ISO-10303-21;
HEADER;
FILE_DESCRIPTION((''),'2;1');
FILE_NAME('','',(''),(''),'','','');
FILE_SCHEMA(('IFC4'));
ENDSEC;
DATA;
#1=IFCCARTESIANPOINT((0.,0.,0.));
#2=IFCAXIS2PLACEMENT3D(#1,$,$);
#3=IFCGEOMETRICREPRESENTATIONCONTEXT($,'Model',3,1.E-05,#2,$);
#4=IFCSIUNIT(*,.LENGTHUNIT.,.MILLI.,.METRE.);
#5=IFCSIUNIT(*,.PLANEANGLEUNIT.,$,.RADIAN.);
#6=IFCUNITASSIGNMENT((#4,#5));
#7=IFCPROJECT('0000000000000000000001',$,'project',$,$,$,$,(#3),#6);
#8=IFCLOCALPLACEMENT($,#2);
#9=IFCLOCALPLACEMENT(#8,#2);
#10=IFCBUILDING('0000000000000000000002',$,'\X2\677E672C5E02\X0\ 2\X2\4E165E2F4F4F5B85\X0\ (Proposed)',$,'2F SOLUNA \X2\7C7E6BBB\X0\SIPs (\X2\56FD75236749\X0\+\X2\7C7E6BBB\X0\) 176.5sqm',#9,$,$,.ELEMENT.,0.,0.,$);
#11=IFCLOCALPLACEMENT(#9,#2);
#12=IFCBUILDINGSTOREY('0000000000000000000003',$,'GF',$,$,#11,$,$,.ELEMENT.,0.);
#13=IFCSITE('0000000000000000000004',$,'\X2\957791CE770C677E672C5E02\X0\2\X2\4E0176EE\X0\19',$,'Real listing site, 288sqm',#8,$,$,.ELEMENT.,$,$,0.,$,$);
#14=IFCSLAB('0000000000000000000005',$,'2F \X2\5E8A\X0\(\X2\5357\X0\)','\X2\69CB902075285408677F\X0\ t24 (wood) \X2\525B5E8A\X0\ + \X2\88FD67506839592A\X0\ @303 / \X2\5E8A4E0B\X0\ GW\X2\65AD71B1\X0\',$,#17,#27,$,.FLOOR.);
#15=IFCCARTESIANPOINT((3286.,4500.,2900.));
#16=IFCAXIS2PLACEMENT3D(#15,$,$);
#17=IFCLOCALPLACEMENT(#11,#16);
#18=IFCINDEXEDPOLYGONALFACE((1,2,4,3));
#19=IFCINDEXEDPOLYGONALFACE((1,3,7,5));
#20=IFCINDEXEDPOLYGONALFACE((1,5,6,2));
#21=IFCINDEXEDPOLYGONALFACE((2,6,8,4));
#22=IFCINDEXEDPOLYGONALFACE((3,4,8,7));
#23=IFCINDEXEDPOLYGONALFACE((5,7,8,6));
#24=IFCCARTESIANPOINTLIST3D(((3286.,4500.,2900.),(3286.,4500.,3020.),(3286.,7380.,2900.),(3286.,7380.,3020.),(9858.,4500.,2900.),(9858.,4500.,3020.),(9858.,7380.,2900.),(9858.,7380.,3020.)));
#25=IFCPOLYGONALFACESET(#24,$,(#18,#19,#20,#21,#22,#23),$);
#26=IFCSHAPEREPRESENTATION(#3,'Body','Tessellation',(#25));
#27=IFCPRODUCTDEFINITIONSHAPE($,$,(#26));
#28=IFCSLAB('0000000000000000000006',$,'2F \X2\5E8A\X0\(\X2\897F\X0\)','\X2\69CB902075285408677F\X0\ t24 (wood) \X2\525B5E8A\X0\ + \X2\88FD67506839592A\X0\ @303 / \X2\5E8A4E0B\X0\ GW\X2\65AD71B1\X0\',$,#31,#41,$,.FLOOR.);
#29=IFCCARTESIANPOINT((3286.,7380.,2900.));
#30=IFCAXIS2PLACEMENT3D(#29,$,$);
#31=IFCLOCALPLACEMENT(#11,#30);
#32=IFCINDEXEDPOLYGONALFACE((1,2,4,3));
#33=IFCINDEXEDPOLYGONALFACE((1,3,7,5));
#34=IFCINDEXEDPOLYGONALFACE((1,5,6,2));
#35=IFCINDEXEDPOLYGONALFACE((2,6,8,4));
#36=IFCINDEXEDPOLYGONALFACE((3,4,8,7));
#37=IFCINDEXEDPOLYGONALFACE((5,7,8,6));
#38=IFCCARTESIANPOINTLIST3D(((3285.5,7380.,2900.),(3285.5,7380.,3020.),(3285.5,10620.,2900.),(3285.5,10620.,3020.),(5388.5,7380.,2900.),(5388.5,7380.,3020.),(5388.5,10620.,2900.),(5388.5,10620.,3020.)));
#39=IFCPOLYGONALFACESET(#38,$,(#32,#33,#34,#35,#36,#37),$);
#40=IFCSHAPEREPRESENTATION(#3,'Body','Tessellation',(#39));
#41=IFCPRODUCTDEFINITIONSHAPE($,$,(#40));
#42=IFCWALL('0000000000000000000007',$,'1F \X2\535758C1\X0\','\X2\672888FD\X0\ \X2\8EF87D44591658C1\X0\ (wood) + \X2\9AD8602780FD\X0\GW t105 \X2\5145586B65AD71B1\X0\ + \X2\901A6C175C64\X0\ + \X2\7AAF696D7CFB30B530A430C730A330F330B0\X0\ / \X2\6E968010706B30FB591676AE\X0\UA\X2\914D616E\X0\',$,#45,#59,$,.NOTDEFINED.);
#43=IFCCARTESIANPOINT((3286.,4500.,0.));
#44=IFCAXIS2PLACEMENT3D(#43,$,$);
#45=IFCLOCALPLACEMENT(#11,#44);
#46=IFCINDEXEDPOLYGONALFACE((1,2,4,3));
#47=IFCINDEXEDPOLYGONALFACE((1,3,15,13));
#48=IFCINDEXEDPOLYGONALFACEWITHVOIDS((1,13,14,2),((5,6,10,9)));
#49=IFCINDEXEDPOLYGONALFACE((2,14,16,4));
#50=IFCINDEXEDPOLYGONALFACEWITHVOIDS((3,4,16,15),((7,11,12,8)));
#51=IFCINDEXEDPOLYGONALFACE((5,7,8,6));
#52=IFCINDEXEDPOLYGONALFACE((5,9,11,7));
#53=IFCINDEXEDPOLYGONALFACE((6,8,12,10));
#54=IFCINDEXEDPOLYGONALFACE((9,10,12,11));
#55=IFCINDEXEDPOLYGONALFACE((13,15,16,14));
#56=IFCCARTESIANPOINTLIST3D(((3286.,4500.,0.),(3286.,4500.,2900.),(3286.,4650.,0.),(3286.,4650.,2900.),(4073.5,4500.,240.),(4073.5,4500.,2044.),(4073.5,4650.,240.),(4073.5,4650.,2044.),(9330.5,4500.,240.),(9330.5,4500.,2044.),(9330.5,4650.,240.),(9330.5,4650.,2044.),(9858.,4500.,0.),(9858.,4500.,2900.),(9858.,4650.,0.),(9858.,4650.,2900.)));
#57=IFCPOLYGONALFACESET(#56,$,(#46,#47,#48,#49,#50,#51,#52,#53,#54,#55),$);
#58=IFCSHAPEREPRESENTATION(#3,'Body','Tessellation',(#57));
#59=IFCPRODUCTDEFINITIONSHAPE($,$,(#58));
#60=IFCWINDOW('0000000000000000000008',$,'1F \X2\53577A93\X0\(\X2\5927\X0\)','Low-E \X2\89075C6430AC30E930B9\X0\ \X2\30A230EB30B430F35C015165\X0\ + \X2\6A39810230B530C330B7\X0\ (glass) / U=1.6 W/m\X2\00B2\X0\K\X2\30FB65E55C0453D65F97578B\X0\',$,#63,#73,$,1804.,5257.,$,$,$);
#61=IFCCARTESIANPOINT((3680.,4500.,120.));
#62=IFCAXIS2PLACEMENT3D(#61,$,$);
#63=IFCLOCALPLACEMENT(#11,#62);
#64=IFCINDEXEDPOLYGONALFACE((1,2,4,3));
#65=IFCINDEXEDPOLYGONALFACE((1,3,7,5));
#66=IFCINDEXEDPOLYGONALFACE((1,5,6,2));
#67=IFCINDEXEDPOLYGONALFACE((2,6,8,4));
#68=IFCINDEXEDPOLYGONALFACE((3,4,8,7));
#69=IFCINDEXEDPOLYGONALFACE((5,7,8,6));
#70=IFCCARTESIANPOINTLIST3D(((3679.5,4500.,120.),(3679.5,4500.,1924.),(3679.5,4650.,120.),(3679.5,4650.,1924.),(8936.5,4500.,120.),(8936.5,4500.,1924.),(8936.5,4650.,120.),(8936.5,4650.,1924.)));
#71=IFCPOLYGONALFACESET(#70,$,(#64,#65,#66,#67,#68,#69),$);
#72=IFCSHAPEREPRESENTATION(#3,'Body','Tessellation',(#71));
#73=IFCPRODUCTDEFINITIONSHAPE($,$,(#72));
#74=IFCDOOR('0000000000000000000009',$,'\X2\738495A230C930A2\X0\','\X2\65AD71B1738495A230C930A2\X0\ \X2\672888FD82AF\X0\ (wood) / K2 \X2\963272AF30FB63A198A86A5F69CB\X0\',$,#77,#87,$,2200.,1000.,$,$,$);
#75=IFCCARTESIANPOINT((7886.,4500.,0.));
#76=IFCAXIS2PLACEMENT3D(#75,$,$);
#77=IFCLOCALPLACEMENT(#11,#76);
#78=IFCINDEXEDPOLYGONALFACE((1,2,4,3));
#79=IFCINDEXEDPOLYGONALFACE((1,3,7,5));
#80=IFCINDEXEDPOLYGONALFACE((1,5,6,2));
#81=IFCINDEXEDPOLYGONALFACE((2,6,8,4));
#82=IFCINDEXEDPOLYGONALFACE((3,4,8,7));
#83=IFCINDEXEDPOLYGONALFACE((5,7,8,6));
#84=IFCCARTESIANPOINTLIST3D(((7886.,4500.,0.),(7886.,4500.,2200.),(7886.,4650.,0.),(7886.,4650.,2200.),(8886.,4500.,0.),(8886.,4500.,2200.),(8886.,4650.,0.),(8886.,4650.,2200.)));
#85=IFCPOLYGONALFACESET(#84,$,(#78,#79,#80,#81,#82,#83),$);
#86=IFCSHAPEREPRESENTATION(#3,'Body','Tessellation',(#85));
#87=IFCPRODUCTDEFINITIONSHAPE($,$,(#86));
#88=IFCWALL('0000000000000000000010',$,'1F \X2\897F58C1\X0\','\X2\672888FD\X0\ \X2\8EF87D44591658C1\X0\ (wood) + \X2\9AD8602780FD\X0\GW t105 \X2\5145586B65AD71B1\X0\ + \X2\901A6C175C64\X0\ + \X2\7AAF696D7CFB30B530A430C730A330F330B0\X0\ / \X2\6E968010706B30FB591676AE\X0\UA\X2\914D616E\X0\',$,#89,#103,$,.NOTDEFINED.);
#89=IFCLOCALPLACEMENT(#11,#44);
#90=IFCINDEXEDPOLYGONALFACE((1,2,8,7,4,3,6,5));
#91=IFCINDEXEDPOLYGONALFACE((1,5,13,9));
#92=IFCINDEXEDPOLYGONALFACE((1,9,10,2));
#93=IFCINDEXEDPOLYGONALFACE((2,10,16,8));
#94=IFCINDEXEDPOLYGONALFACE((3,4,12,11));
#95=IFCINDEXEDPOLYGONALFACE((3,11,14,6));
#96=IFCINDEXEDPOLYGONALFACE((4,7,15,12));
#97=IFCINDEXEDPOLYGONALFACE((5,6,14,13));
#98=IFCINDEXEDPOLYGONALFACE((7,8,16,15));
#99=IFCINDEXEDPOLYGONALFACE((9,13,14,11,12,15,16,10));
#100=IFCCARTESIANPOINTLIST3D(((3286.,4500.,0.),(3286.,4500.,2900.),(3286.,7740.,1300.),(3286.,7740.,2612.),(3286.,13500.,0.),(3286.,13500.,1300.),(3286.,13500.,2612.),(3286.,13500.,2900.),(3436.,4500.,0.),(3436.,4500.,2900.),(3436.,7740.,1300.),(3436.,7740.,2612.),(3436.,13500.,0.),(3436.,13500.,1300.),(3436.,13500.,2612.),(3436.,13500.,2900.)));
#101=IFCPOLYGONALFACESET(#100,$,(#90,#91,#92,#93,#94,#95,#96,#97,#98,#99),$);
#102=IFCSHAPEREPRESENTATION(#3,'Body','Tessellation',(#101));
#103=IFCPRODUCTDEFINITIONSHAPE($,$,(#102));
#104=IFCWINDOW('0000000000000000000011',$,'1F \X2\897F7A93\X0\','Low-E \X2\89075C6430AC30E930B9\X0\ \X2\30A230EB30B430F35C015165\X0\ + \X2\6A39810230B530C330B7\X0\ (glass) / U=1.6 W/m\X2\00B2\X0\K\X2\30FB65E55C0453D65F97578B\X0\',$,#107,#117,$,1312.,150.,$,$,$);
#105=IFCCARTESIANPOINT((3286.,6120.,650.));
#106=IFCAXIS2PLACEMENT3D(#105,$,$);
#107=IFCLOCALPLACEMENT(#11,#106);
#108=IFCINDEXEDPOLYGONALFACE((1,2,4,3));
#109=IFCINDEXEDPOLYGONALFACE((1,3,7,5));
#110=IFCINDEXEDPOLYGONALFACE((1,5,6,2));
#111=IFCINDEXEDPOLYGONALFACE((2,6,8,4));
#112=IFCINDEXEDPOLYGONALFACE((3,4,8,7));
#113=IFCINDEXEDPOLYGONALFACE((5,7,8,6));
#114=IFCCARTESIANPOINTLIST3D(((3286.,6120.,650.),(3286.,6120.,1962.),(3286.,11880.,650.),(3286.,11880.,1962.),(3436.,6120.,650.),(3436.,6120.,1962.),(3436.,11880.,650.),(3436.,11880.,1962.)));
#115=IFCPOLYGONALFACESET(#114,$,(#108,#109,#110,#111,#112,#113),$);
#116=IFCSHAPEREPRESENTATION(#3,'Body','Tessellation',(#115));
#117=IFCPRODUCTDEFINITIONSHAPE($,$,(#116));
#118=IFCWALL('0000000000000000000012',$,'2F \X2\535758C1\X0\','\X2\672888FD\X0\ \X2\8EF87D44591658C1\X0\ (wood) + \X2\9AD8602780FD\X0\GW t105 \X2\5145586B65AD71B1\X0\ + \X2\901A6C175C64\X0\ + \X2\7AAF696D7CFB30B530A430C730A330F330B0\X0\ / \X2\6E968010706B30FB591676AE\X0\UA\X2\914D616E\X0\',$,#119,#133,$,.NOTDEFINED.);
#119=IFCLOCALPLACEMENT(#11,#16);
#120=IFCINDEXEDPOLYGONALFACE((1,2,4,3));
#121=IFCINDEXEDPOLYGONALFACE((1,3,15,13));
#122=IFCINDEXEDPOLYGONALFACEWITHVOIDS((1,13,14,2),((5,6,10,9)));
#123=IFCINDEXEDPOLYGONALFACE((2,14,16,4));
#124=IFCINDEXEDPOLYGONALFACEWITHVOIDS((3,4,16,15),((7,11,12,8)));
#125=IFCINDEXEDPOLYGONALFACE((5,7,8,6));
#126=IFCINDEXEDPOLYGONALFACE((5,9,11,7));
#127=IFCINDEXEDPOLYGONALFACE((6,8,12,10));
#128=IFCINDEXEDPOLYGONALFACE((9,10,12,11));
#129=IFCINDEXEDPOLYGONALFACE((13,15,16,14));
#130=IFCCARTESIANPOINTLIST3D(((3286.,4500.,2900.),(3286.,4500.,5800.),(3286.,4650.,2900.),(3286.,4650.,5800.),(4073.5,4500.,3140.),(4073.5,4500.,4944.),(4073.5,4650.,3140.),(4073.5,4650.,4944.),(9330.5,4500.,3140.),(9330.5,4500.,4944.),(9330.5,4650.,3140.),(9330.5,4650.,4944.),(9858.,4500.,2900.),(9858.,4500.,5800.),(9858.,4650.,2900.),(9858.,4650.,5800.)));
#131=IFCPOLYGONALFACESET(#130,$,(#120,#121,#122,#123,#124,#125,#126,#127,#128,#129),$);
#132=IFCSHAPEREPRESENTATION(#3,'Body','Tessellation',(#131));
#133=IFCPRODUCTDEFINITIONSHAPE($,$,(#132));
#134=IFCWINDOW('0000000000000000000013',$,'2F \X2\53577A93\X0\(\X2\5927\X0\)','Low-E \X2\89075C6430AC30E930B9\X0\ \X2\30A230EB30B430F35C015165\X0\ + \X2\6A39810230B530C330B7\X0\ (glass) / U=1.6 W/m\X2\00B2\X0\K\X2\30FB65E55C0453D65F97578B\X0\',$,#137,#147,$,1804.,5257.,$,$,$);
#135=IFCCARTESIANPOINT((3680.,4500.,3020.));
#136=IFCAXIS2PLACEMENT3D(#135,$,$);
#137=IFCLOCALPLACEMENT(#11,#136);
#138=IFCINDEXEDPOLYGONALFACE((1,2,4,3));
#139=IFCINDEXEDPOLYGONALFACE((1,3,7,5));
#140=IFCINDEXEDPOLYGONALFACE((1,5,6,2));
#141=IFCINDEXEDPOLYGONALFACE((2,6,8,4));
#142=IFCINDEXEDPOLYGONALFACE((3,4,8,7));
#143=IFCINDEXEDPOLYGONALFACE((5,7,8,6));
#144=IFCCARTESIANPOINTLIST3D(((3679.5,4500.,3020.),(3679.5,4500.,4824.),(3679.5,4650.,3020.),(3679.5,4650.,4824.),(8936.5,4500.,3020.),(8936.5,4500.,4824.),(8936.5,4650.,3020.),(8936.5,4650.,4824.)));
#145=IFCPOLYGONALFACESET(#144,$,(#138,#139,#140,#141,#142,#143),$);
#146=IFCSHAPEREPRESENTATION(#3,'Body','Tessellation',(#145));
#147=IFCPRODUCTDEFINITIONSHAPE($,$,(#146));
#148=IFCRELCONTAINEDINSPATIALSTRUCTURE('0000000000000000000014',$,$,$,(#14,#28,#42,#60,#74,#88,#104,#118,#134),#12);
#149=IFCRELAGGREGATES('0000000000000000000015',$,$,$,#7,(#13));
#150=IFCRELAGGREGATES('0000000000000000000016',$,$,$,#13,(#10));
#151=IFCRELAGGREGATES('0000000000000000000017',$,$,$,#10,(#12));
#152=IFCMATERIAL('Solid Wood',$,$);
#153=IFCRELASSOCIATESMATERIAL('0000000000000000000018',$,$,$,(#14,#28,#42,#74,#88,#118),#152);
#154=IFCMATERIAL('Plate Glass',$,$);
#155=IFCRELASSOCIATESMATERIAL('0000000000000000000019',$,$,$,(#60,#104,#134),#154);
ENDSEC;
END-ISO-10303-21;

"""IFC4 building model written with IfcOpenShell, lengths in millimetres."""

from ifc_helpers import new_model, si_unit, frame, frame_2d, origin, place, context, project, spatial, rectangle, extrude, material, element, fill, save


model = new_model("IFC4")

# Units and contexts
model_context = context("Model", 3, precision=1e-05, world=origin())
ifc_project = project(units=[si_unit("LENGTHUNIT", "METRE", prefix="MILLI"), si_unit("PLANEANGLEUNIT", "RADIAN")], contexts=[model_context])

# Site, building, storey
site_placement = place(None, origin())
site = spatial("IfcSite", under=ifc_project, at=site_placement, Name="長野県松本市2丁目19", ObjectType="Real listing site, 288sqm", CompositionType="ELEMENT", RefElevation=0.0)
building_placement = place(site_placement, origin())
building = spatial("IfcBuilding", under=site, at=building_placement, Name="松本市 2世帯住宅 (Proposed)", ObjectType="2F SOLUNA 籾殻SIPs (国産杉+籾殻) 176.5sqm", CompositionType="ELEMENT", ElevationOfRefHeight=0.0, ElevationOfTerrain=0.0)
storey_placement = place(building_placement, origin())
storey = spatial("IfcBuildingStorey", under=building, at=storey_placement, Name="GF", CompositionType="ELEMENT", Elevation=0.0)

# Slabs
ifc_material_1 = material(Name="Solid Wood")
slab_1_placement = place(storey_placement, frame((3286.0, 4500.0, 2900.0)))
element("IfcSlab", 1, at=slab_1_placement, inside=storey, material=ifc_material_1, Name="2F 床(南)", Description="構造用合板 t24 (wood) 剛床 + 製材根太 @303 / 床下 GW断熱", PredefinedType="FLOOR", context=model_context, shape_type="SweptSolid", body=[
    extrude(rectangle(XDim=6572.0, YDim=2880.0, at=frame_2d((3286.0, 1440.0))), frame((3286.0, 4500.0, 2900.0)), (0.0, 0.0, 1.0), 120.0),
])
slab_2_placement = place(storey_placement, frame((3286.0, 7380.0, 2900.0)))
element("IfcSlab", 2, at=slab_2_placement, inside=storey, material=ifc_material_1, Name="2F 床(西)", Description="構造用合板 t24 (wood) 剛床 + 製材根太 @303 / 床下 GW断熱", PredefinedType="FLOOR", context=model_context, shape_type="SweptSolid", body=[
    extrude(rectangle(XDim=2103.0, YDim=3240.0, at=frame_2d((1051.0, 1620.0))), frame((3286.0, 7380.0, 2900.0)), (0.0, 0.0, 1.0), 120.0),
])

# Wall, openings, window, door
wall_1_placement = place(storey_placement, frame((3286.0, 4500.0, 0.0)))
wall_1 = element("IfcWall", 3, at=wall_1_placement, inside=storey, material=ifc_material_1, Name="1F 南壁", Description="木製 軸組外壁 (wood) + 高性能GW t105 充填断熱 + 通気層 + 窯業系サイディング / 準耐火・外皮UA配慮", PredefinedType="NOTDEFINED", context=model_context, shape_type="SweptSolid", body=[
    extrude(rectangle(XDim=6572.0, YDim=150.0, at=frame_2d((3286.0, 75.0))), frame((3286.0, 4500.0, 0.0)), (0.0, 0.0, 1.0), 2900.0),
])
opening_1_placement = place(storey_placement, frame((3680.0, 4500.0, 120.0)))
opening_1 = element("IfcOpeningElement", 4, at=opening_1_placement, cuts=wall_1, PredefinedType="NOTDEFINED", context=model_context, shape_type="SweptSolid", body=[
    extrude(rectangle(XDim=5257.0, YDim=150.0, at=frame_2d((2628.0, 75.0))), frame((3680.0, 4500.0, 120.0)), (0.0, 0.0, 1.0), 1804.0),
])
opening_2_placement = place(storey_placement, frame((7886.0, 4500.0, 0.0)))
opening_2 = element("IfcOpeningElement", 5, at=opening_2_placement, cuts=wall_1, PredefinedType="NOTDEFINED", context=model_context, shape_type="SweptSolid", body=[
    extrude(rectangle(XDim=1000.0, YDim=150.0, at=frame_2d((500.0, 75.0))), frame((7886.0, 4500.0, 0.0)), (0.0, 0.0, 1.0), 2200.0),
])
ifc_material_2 = material(Name="Plate Glass")
window_1_placement = place(storey_placement, frame((3680.0, 4500.0, 120.0)))
window_1 = element("IfcWindow", 6, at=window_1_placement, inside=storey, material=ifc_material_2, Name="1F 南窓(大)", Description="Low-E 複層ガラス アルゴン封入 + 樹脂サッシ (glass) / U=1.6 W/m²K・日射取得型", OverallHeight=1804.0, OverallWidth=5257.0, context=model_context, shape_type="SweptSolid", body=[
    extrude(rectangle(XDim=5257.0, YDim=150.0, at=frame_2d((2628.0, 75.0))), frame((3680.0, 4500.0, 120.0)), (0.0, 0.0, 1.0), 1804.0),
])
fill(opening_1, window_1)
door_placement = place(storey_placement, frame((7886.0, 4500.0, 0.0)))
door = element("IfcDoor", 7, at=door_placement, inside=storey, material=ifc_material_1, Name="玄関ドア", Description="断熱玄関ドア 木製芯 (wood) / K2 防犯・採風機構", OverallHeight=2200.0, OverallWidth=1000.0, context=model_context, shape_type="SweptSolid", body=[
    extrude(rectangle(XDim=1000.0, YDim=150.0, at=frame_2d((500.0, 75.0))), frame((7886.0, 4500.0, 0.0)), (0.0, 0.0, 1.0), 2200.0),
])
fill(opening_2, door)

# Walls, openings, windows
wall_2_placement = place(storey_placement, frame((3286.0, 4500.0, 0.0)))
wall_2 = element("IfcWall", 8, at=wall_2_placement, inside=storey, material=ifc_material_1, Name="1F 西壁", Description="木製 軸組外壁 (wood) + 高性能GW t105 充填断熱 + 通気層 + 窯業系サイディング / 準耐火・外皮UA配慮", PredefinedType="NOTDEFINED", context=model_context, shape_type="SweptSolid", body=[
    extrude(rectangle(XDim=150.0, YDim=9000.0, at=frame_2d((75.0, 4500.0))), frame((3286.0, 4500.0, 0.0)), (0.0, 0.0, 1.0), 2900.0),
])
opening_3_placement = place(storey_placement, frame((3286.0, 6120.0, 650.0)))
opening_3 = element("IfcOpeningElement", 9, at=opening_3_placement, cuts=wall_2, PredefinedType="NOTDEFINED", context=model_context, shape_type="SweptSolid", body=[
    extrude(rectangle(XDim=150.0, YDim=5760.0, at=frame_2d((75.0, 2880.0))), frame((3286.0, 6120.0, 650.0)), (0.0, 0.0, 1.0), 1312.0),
])
window_2_placement = place(storey_placement, frame((3286.0, 6120.0, 650.0)))
window_2 = element("IfcWindow", 10, at=window_2_placement, inside=storey, material=ifc_material_2, Name="1F 西窓", Description="Low-E 複層ガラス アルゴン封入 + 樹脂サッシ (glass) / U=1.6 W/m²K・日射取得型", OverallHeight=1312.0, OverallWidth=150.0, context=model_context, shape_type="SweptSolid", body=[
    extrude(rectangle(XDim=150.0, YDim=5760.0, at=frame_2d((75.0, 2880.0))), frame((3286.0, 6120.0, 650.0)), (0.0, 0.0, 1.0), 1312.0),
])
fill(opening_3, window_2)
wall_3_placement = place(storey_placement, frame((3286.0, 4500.0, 2900.0)))
wall_3 = element("IfcWall", 11, at=wall_3_placement, inside=storey, material=ifc_material_1, Name="2F 南壁", Description="木製 軸組外壁 (wood) + 高性能GW t105 充填断熱 + 通気層 + 窯業系サイディング / 準耐火・外皮UA配慮", PredefinedType="NOTDEFINED", context=model_context, shape_type="SweptSolid", body=[
    extrude(rectangle(XDim=6572.0, YDim=150.0, at=frame_2d((3286.0, 75.0))), frame((3286.0, 4500.0, 2900.0)), (0.0, 0.0, 1.0), 2900.0),
])
opening_4_placement = place(storey_placement, frame((3680.0, 4500.0, 3020.0)))
opening_4 = element("IfcOpeningElement", 12, at=opening_4_placement, cuts=wall_3, PredefinedType="NOTDEFINED", context=model_context, shape_type="SweptSolid", body=[
    extrude(rectangle(XDim=5257.0, YDim=150.0, at=frame_2d((2628.0, 75.0))), frame((3680.0, 4500.0, 3020.0)), (0.0, 0.0, 1.0), 1804.0),
])
window_3_placement = place(storey_placement, frame((3680.0, 4500.0, 3020.0)))
window_3 = element("IfcWindow", 13, at=window_3_placement, inside=storey, material=ifc_material_2, Name="2F 南窓(大)", Description="Low-E 複層ガラス アルゴン封入 + 樹脂サッシ (glass) / U=1.6 W/m²K・日射取得型", OverallHeight=1804.0, OverallWidth=5257.0, context=model_context, shape_type="SweptSolid", body=[
    extrude(rectangle(XDim=5257.0, YDim=150.0, at=frame_2d((2628.0, 75.0))), frame((3680.0, 4500.0, 3020.0)), (0.0, 0.0, 1.0), 1804.0),
])
fill(opening_4, window_3)

save(model, "model.ifc")
